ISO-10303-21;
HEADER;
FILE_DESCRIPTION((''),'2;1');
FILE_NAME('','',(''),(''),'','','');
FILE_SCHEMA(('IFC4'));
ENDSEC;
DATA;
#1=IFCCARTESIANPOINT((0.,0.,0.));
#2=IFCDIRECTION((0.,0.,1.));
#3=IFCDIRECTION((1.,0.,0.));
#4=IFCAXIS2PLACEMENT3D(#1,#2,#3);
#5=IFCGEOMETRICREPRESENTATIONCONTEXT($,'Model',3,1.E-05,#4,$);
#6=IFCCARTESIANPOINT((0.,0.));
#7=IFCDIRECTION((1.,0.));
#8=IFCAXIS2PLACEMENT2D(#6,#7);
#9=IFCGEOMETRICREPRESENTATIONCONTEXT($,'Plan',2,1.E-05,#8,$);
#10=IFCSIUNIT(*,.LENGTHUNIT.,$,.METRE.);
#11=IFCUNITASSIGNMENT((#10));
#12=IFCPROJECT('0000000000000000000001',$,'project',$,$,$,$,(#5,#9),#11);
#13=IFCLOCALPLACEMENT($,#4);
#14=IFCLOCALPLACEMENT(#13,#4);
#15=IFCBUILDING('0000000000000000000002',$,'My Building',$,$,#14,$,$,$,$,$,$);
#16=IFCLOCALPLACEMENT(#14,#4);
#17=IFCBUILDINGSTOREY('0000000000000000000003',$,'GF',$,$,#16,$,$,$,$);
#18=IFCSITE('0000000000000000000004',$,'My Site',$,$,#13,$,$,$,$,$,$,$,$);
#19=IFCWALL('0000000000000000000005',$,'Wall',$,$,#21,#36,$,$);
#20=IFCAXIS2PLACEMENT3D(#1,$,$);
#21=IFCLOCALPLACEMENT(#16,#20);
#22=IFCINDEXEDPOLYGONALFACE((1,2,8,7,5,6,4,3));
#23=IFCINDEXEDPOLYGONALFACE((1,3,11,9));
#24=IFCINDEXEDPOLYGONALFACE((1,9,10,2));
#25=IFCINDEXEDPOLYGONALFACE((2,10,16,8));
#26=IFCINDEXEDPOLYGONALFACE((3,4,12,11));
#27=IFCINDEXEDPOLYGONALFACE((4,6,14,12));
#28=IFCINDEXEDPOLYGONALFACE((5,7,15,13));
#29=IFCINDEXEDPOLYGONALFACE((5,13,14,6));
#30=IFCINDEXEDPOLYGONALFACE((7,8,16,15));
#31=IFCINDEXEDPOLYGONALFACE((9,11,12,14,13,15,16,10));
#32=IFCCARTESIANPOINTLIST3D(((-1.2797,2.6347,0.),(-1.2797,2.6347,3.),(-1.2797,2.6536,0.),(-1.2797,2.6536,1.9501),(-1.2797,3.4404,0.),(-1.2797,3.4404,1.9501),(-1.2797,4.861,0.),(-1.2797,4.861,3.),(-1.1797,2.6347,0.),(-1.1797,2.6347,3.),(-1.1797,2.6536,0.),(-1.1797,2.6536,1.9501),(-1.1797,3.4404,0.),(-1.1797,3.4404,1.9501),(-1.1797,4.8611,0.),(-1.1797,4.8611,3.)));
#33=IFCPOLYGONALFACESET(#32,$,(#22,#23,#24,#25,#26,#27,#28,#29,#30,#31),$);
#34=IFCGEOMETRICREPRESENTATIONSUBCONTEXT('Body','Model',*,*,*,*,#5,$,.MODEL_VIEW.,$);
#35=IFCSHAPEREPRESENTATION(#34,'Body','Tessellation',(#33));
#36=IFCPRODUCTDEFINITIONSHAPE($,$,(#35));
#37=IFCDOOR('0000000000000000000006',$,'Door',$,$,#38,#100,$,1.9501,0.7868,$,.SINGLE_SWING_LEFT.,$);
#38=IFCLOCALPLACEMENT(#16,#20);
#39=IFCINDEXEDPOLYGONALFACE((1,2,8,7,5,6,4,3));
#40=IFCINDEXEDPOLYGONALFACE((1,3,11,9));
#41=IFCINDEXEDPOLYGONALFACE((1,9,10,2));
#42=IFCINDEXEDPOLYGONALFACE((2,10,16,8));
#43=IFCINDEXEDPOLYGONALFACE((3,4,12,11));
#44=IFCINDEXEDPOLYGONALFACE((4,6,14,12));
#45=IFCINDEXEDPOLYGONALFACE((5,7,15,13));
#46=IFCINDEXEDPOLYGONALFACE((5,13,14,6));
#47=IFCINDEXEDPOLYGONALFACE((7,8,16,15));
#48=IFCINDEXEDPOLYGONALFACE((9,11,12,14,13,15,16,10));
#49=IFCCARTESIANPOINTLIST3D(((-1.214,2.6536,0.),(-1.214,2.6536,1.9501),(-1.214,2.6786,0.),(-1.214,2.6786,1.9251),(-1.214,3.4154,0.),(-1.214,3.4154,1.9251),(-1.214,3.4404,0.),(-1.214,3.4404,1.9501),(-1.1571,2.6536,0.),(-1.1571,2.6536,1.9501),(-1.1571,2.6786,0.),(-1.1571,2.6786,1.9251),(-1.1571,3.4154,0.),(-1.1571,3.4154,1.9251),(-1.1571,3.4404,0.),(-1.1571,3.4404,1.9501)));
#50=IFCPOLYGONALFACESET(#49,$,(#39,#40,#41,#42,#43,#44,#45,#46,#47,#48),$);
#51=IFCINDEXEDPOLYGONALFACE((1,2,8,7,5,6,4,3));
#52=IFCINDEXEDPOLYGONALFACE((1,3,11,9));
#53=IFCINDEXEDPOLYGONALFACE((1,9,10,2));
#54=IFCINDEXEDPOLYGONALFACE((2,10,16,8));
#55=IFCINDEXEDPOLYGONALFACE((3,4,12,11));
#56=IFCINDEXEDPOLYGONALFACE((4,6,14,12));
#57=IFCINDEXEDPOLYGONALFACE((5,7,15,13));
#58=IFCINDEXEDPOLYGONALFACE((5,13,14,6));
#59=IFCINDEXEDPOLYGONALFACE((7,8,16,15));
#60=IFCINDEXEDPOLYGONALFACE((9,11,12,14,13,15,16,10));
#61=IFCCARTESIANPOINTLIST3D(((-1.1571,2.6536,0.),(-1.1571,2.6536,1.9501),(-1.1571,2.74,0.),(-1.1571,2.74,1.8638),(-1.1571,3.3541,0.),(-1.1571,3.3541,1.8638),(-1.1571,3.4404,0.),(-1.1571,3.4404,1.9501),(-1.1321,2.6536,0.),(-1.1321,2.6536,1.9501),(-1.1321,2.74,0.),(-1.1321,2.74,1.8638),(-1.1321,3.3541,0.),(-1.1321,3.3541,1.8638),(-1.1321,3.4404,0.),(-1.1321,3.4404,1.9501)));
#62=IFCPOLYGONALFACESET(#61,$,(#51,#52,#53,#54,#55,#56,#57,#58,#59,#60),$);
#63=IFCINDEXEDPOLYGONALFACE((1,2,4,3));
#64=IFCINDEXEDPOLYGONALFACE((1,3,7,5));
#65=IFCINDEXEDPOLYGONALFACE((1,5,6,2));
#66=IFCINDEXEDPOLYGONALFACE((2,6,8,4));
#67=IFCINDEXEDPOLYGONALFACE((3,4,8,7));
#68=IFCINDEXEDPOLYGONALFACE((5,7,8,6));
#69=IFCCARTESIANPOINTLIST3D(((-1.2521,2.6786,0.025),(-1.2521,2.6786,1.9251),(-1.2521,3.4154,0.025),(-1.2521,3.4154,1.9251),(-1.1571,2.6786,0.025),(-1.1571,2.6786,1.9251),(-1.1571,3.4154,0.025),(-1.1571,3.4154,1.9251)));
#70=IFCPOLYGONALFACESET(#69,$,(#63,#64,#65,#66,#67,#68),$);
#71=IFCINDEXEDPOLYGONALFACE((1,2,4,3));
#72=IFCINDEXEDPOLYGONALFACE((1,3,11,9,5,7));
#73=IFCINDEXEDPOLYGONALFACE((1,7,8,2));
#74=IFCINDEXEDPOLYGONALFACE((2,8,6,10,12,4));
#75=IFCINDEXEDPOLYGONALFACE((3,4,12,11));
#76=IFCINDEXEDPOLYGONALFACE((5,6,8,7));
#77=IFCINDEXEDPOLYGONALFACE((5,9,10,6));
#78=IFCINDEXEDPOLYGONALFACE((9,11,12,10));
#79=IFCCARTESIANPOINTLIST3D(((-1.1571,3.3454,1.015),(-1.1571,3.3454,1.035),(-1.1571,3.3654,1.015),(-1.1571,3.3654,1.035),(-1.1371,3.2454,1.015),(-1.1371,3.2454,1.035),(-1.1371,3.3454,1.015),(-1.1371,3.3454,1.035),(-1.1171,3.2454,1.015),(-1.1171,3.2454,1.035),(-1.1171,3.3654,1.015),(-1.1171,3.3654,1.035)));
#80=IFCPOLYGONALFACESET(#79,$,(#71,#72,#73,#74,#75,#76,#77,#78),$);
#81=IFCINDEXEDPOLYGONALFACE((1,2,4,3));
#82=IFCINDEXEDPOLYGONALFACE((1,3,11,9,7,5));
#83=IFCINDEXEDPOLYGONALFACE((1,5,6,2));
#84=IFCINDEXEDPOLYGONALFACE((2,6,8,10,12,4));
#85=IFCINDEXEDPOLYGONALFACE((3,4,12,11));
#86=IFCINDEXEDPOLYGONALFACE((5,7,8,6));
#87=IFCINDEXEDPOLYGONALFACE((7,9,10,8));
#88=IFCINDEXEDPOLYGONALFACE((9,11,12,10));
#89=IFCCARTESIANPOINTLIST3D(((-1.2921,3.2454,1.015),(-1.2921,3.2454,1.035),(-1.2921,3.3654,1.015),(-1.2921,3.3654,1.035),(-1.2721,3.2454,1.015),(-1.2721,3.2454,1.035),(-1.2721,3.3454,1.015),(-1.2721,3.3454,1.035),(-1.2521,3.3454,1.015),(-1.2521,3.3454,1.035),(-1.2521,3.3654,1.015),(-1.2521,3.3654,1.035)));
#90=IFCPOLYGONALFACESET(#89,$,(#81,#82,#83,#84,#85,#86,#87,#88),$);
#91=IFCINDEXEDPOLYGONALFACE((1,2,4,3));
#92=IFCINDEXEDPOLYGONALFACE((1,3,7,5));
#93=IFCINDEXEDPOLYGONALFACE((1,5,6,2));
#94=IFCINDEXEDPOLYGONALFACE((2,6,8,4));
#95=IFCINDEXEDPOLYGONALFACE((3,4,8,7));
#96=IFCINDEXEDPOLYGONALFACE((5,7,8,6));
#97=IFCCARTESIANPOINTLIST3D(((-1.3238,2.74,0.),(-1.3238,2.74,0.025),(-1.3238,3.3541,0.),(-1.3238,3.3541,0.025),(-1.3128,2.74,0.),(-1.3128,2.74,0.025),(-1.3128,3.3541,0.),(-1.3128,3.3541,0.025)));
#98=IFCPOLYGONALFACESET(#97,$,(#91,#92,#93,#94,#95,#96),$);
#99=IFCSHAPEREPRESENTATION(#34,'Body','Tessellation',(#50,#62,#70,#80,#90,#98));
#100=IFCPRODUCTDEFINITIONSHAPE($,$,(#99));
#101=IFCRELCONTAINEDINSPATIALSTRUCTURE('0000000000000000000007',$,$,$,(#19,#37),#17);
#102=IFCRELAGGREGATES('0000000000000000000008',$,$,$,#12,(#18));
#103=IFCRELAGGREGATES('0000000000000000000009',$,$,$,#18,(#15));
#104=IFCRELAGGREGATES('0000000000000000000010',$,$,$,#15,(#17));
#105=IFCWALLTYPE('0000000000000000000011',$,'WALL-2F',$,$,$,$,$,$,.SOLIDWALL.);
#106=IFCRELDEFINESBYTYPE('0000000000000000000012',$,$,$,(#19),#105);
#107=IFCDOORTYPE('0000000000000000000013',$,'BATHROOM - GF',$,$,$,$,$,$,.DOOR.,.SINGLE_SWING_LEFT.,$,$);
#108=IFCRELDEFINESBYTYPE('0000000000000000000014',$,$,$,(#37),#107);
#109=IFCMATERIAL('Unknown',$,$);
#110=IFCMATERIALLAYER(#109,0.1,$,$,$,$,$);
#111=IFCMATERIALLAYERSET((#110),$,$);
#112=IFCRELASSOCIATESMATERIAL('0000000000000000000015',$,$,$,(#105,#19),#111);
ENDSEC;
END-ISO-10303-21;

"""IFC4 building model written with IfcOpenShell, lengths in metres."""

from ifc_helpers import new_model, entity, si_unit, frame, origin_with_axes, origin_2d_with_axis, place, context, subcontext, project, spatial, line, indexed_curve, outline, extrude, shape, source, transform, mapped, material, layer, layer_set, layer_usage, type_object, type_shapes, element, fill, save


model = new_model("IFC4")

# Units and contexts
model_context = context("Model", 3, precision=1e-05, world=origin_with_axes())
plan_context = context("Plan", 2, precision=1e-05, world=origin_2d_with_axis())
body_context_1 = subcontext(model_context, "Body", "Model", "MODEL_VIEW")
body_context_2 = subcontext(plan_context, "Body", "Plan", "PLAN_VIEW")
ifc_project = project(units=[si_unit("LENGTHUNIT", "METRE")], contexts=[model_context, plan_context])

# Site, building, storey
site_placement = place(None, origin_with_axes())
site = spatial("IfcSite", under=ifc_project, at=site_placement, Name="My Site")
building_placement = place(site_placement, origin_with_axes())
building = spatial("IfcBuilding", under=site, at=building_placement, Name="My Building")
storey_placement = place(building_placement, origin_with_axes())
storey = spatial("IfcBuildingStorey", under=building, at=storey_placement, Name="GF")

# Shared definitions
ifc_material = material(Name="Unknown")

# Shared definitions
ifc_layer_1 = layer(ifc_material, 0.1)
ifc_layer_set_1 = layer_set([ifc_layer_1])
wall_type_1 = type_object("IfcWallType", Name="WALL-2F", PredefinedType="SOLIDWALL", material=ifc_layer_set_1)

# Wall, opening, door
ifc_layer_usage_1 = layer_usage(ifc_layer_set_1, "AXIS2", "POSITIVE", 0.0)
wall_1_placement = place(storey_placement, frame((-1.1797, 2.6347, 0.0), z_axis=(0.0, 0.0, 1.0), x_axis=(0.0, 1.0, 0.0)))
wall_1 = element("IfcWall", 1, at=wall_1_placement, inside=storey, type_object=wall_type_1, material=ifc_layer_usage_1, Name="Wall", context=body_context_1, shape_type="SweptSolid", body=[
    extrude(outline(indexed_curve([(0.0, 0.0), (0.0, 0.1), (2.2263, 0.1), (2.2264, 0.0)], segments=[line(1, 2, 3, 4, 1)])), origin_with_axes(), (0.0, 0.0, 1.0), 3.0),
])
shared_shape_1 = source(origin_with_axes(), body_context_1, "Body", "SweptSolid", [
    extrude(outline(indexed_curve([(0.0, 0.0), (0.7868, 0.0), (0.7868, 1.9501), (0.0, 1.9501)], segments=[line(1, 2, 3, 4, 1)])), frame((0.0, -0.6, 0.0), z_axis=(0.0, -1.0, 0.0), x_axis=(1.0, 0.0, 0.0)), (0.0, 0.0, -1.0), 1.2),
])
opening_1_placement = place(wall_1_placement, frame((0.0189, -0.0319, 0.0), z_axis=(0.0, 0.0, 1.0), x_axis=(1.0, 0.0, 0.0)))
opening_1 = element("IfcOpeningElement", 2, at=opening_1_placement, cuts=wall_1, PredefinedType="OPENING", context=body_context_1, shape_type="MappedRepresentation", body=[
    mapped(shared_shape_1, transform((0.0, 0.0, 0.0), x_axis=(1.0, 0.0, 0.0), y_axis=(0.0, 1.0, 0.0), z_axis=(0.0, 0.0, 1.0), scale=1.0)),
])
door_type_1 = type_object("IfcDoorType", Name="BATHROOM - GF", OperationType="SINGLE_SWING_LEFT", PredefinedType="DOOR")
shared_shape_2 = source(origin_with_axes(), body_context_1, "Body", "SweptSolid", [
    extrude(outline(indexed_curve([(0.0, 0.0), (0.0, 1.9501), (0.7868, 1.9501), (0.7868, 0.0), (0.7618, 0.0), (0.7618, 1.9251), (0.025, 1.9251), (0.025, 0.0)], segments=[line(1, 2, 3, 4, 5, 6, 7, 8, 1)])), frame((0.0, 0.0093, 0.0), z_axis=(0.0, -1.0, 0.0), x_axis=(1.0, 0.0, 0.0)), (0.0, 0.0, -1.0), 0.0569),
    extrude(outline(indexed_curve([(0.0, 0.0), (0.0, 1.9501), (0.7868, 1.9501), (0.7868, 0.0), (0.7005, 0.0), (0.7005, 1.8638), (0.0864, 1.8638), (0.0864, 0.0)], segments=[line(1, 2, 3, 4, 5, 6, 7, 8, 1)])), frame((0.0, -0.0157, 0.0), z_axis=(0.0, -1.0, 0.0), x_axis=(1.0, 0.0, 0.0)), (0.0, 0.0, -1.0), 0.025),
    extrude(outline(indexed_curve([(0.0, 0.0), (0.7368, 0.0), (0.7368, 0.095), (0.0, 0.095)], segments=[line(1, 2, 3, 4, 1)])), frame((0.025, 0.0093, 0.025), z_axis=(0.0, 0.0, 1.0), x_axis=(1.0, 0.0, 0.0)), (0.0, 0.0, 1.0), 1.9001),
    extrude(outline(indexed_curve([(0.0, 0.0), (0.0, -0.04), (-0.12, -0.04), (-0.12, -0.02), (-0.02, -0.02), (-0.02, 0.0)], segments=[line(1, 2, 3, 4, 5, 6, 1)])), frame((0.7118, 0.0093, 1.015), z_axis=(0.0, 0.0, 1.0), x_axis=(1.0, 0.0, 0.0)), (0.0, 0.0, 1.0), 0.02),
    extrude(outline(indexed_curve([(0.0, 0.0), (0.0, 0.04), (-0.12, 0.04), (-0.12, 0.02), (-0.02, 0.02), (-0.02, 0.0)], segments=[line(1, 2, 3, 4, 5, 6, 1)])), frame((0.7118, 0.1043, 1.015), z_axis=(0.0, 0.0, 1.0), x_axis=(1.0, 0.0, 0.0)), (0.0, 0.0, 1.0), 0.02),
    extrude(outline(indexed_curve([(0.0, 0.0), (0.6141, 0.0), (0.6141, 0.011), (0.0, 0.011)], segments=[line(1, 2, 3, 4, 1)])), frame((0.0864, 0.165, 0.0), z_axis=(0.0, 0.0, 1.0), x_axis=(1.0, 0.0, 0.0)), (0.0, 0.0, 1.0), 0.025),
])
shared_shape_3 = source(origin_with_axes(), body_context_2, "Body", "Curve2D", [
    entity("IfcIndexedPolyCurve", entity("IfcCartesianPointList2D", [[0.0, -0.0157], [0.0, 0.0662], [0.025, 0.0662], [0.025, 0.0093], [0.0864, 0.0093], [0.0864, -0.0157]]), [entity("IfcLineIndex", [1, 2, 3, 4, 5, 6, 1])]),
    entity("IfcIndexedPolyCurve", entity("IfcCartesianPointList2D", [[0.7868, -0.0157], [0.7868, 0.0662], [0.7618, 0.0662], [0.7618, 0.0093], [0.7005, 0.0093], [0.7005, -0.0157]]), [entity("IfcLineIndex", [1, 2, 3, 4, 5, 6, 1])]),
    entity("IfcTrimmedCurve", entity("IfcEllipse", entity("IfcAxis2Placement2D", entity("IfcCartesianPoint", [0.12, 0.0662]), entity("IfcDirection", [1.0, 0.0])), 0.6418, 0.7368), [entity("IfcCartesianPoint", [0.7618, 0.0662])], [entity("IfcCartesianPoint", [0.12, 0.803])], True, "CARTESIAN"),
    entity("IfcIndexedPolyCurve", entity("IfcCartesianPointList2D", [[0.025, 0.0662], [0.12, 0.0662], [0.12, 0.803], [0.025, 0.803]]), [entity("IfcLineIndex", [1, 2, 3, 4, 1])]),
])
type_shapes(door_type_1, [shared_shape_2, shared_shape_3])
door_1_placement = place(opening_1_placement, frame((0.0, 0.0, 0.0), z_axis=(0.0, 0.0, 1.0), x_axis=(1.0, 0.0, 0.0)))
door_1 = element("IfcDoor", 3, at=door_1_placement, inside=storey, type_object=door_type_1, Name="Door", OperationType="SINGLE_SWING_LEFT", OverallHeight=1.9501, OverallWidth=0.7868, shapes=[
    shape(body_context_1, "Body", "MappedRepresentation", [mapped(shared_shape_2, transform((0.0, 0.0, 0.0), x_axis=(1.0, 0.0, 0.0), y_axis=(0.0, 1.0, 0.0), z_axis=(0.0, 0.0, 1.0), scale=1.0))]),
    shape(body_context_2, "Body", "MappedRepresentation", [mapped(shared_shape_3, transform((0.0, 0.0, 0.0), x_axis=(1.0, 0.0, 0.0), y_axis=(0.0, 1.0, 0.0), z_axis=(0.0, 0.0, 1.0), scale=1.0))]),
])
fill(opening_1, door_1)

save(model, "model.ifc")
